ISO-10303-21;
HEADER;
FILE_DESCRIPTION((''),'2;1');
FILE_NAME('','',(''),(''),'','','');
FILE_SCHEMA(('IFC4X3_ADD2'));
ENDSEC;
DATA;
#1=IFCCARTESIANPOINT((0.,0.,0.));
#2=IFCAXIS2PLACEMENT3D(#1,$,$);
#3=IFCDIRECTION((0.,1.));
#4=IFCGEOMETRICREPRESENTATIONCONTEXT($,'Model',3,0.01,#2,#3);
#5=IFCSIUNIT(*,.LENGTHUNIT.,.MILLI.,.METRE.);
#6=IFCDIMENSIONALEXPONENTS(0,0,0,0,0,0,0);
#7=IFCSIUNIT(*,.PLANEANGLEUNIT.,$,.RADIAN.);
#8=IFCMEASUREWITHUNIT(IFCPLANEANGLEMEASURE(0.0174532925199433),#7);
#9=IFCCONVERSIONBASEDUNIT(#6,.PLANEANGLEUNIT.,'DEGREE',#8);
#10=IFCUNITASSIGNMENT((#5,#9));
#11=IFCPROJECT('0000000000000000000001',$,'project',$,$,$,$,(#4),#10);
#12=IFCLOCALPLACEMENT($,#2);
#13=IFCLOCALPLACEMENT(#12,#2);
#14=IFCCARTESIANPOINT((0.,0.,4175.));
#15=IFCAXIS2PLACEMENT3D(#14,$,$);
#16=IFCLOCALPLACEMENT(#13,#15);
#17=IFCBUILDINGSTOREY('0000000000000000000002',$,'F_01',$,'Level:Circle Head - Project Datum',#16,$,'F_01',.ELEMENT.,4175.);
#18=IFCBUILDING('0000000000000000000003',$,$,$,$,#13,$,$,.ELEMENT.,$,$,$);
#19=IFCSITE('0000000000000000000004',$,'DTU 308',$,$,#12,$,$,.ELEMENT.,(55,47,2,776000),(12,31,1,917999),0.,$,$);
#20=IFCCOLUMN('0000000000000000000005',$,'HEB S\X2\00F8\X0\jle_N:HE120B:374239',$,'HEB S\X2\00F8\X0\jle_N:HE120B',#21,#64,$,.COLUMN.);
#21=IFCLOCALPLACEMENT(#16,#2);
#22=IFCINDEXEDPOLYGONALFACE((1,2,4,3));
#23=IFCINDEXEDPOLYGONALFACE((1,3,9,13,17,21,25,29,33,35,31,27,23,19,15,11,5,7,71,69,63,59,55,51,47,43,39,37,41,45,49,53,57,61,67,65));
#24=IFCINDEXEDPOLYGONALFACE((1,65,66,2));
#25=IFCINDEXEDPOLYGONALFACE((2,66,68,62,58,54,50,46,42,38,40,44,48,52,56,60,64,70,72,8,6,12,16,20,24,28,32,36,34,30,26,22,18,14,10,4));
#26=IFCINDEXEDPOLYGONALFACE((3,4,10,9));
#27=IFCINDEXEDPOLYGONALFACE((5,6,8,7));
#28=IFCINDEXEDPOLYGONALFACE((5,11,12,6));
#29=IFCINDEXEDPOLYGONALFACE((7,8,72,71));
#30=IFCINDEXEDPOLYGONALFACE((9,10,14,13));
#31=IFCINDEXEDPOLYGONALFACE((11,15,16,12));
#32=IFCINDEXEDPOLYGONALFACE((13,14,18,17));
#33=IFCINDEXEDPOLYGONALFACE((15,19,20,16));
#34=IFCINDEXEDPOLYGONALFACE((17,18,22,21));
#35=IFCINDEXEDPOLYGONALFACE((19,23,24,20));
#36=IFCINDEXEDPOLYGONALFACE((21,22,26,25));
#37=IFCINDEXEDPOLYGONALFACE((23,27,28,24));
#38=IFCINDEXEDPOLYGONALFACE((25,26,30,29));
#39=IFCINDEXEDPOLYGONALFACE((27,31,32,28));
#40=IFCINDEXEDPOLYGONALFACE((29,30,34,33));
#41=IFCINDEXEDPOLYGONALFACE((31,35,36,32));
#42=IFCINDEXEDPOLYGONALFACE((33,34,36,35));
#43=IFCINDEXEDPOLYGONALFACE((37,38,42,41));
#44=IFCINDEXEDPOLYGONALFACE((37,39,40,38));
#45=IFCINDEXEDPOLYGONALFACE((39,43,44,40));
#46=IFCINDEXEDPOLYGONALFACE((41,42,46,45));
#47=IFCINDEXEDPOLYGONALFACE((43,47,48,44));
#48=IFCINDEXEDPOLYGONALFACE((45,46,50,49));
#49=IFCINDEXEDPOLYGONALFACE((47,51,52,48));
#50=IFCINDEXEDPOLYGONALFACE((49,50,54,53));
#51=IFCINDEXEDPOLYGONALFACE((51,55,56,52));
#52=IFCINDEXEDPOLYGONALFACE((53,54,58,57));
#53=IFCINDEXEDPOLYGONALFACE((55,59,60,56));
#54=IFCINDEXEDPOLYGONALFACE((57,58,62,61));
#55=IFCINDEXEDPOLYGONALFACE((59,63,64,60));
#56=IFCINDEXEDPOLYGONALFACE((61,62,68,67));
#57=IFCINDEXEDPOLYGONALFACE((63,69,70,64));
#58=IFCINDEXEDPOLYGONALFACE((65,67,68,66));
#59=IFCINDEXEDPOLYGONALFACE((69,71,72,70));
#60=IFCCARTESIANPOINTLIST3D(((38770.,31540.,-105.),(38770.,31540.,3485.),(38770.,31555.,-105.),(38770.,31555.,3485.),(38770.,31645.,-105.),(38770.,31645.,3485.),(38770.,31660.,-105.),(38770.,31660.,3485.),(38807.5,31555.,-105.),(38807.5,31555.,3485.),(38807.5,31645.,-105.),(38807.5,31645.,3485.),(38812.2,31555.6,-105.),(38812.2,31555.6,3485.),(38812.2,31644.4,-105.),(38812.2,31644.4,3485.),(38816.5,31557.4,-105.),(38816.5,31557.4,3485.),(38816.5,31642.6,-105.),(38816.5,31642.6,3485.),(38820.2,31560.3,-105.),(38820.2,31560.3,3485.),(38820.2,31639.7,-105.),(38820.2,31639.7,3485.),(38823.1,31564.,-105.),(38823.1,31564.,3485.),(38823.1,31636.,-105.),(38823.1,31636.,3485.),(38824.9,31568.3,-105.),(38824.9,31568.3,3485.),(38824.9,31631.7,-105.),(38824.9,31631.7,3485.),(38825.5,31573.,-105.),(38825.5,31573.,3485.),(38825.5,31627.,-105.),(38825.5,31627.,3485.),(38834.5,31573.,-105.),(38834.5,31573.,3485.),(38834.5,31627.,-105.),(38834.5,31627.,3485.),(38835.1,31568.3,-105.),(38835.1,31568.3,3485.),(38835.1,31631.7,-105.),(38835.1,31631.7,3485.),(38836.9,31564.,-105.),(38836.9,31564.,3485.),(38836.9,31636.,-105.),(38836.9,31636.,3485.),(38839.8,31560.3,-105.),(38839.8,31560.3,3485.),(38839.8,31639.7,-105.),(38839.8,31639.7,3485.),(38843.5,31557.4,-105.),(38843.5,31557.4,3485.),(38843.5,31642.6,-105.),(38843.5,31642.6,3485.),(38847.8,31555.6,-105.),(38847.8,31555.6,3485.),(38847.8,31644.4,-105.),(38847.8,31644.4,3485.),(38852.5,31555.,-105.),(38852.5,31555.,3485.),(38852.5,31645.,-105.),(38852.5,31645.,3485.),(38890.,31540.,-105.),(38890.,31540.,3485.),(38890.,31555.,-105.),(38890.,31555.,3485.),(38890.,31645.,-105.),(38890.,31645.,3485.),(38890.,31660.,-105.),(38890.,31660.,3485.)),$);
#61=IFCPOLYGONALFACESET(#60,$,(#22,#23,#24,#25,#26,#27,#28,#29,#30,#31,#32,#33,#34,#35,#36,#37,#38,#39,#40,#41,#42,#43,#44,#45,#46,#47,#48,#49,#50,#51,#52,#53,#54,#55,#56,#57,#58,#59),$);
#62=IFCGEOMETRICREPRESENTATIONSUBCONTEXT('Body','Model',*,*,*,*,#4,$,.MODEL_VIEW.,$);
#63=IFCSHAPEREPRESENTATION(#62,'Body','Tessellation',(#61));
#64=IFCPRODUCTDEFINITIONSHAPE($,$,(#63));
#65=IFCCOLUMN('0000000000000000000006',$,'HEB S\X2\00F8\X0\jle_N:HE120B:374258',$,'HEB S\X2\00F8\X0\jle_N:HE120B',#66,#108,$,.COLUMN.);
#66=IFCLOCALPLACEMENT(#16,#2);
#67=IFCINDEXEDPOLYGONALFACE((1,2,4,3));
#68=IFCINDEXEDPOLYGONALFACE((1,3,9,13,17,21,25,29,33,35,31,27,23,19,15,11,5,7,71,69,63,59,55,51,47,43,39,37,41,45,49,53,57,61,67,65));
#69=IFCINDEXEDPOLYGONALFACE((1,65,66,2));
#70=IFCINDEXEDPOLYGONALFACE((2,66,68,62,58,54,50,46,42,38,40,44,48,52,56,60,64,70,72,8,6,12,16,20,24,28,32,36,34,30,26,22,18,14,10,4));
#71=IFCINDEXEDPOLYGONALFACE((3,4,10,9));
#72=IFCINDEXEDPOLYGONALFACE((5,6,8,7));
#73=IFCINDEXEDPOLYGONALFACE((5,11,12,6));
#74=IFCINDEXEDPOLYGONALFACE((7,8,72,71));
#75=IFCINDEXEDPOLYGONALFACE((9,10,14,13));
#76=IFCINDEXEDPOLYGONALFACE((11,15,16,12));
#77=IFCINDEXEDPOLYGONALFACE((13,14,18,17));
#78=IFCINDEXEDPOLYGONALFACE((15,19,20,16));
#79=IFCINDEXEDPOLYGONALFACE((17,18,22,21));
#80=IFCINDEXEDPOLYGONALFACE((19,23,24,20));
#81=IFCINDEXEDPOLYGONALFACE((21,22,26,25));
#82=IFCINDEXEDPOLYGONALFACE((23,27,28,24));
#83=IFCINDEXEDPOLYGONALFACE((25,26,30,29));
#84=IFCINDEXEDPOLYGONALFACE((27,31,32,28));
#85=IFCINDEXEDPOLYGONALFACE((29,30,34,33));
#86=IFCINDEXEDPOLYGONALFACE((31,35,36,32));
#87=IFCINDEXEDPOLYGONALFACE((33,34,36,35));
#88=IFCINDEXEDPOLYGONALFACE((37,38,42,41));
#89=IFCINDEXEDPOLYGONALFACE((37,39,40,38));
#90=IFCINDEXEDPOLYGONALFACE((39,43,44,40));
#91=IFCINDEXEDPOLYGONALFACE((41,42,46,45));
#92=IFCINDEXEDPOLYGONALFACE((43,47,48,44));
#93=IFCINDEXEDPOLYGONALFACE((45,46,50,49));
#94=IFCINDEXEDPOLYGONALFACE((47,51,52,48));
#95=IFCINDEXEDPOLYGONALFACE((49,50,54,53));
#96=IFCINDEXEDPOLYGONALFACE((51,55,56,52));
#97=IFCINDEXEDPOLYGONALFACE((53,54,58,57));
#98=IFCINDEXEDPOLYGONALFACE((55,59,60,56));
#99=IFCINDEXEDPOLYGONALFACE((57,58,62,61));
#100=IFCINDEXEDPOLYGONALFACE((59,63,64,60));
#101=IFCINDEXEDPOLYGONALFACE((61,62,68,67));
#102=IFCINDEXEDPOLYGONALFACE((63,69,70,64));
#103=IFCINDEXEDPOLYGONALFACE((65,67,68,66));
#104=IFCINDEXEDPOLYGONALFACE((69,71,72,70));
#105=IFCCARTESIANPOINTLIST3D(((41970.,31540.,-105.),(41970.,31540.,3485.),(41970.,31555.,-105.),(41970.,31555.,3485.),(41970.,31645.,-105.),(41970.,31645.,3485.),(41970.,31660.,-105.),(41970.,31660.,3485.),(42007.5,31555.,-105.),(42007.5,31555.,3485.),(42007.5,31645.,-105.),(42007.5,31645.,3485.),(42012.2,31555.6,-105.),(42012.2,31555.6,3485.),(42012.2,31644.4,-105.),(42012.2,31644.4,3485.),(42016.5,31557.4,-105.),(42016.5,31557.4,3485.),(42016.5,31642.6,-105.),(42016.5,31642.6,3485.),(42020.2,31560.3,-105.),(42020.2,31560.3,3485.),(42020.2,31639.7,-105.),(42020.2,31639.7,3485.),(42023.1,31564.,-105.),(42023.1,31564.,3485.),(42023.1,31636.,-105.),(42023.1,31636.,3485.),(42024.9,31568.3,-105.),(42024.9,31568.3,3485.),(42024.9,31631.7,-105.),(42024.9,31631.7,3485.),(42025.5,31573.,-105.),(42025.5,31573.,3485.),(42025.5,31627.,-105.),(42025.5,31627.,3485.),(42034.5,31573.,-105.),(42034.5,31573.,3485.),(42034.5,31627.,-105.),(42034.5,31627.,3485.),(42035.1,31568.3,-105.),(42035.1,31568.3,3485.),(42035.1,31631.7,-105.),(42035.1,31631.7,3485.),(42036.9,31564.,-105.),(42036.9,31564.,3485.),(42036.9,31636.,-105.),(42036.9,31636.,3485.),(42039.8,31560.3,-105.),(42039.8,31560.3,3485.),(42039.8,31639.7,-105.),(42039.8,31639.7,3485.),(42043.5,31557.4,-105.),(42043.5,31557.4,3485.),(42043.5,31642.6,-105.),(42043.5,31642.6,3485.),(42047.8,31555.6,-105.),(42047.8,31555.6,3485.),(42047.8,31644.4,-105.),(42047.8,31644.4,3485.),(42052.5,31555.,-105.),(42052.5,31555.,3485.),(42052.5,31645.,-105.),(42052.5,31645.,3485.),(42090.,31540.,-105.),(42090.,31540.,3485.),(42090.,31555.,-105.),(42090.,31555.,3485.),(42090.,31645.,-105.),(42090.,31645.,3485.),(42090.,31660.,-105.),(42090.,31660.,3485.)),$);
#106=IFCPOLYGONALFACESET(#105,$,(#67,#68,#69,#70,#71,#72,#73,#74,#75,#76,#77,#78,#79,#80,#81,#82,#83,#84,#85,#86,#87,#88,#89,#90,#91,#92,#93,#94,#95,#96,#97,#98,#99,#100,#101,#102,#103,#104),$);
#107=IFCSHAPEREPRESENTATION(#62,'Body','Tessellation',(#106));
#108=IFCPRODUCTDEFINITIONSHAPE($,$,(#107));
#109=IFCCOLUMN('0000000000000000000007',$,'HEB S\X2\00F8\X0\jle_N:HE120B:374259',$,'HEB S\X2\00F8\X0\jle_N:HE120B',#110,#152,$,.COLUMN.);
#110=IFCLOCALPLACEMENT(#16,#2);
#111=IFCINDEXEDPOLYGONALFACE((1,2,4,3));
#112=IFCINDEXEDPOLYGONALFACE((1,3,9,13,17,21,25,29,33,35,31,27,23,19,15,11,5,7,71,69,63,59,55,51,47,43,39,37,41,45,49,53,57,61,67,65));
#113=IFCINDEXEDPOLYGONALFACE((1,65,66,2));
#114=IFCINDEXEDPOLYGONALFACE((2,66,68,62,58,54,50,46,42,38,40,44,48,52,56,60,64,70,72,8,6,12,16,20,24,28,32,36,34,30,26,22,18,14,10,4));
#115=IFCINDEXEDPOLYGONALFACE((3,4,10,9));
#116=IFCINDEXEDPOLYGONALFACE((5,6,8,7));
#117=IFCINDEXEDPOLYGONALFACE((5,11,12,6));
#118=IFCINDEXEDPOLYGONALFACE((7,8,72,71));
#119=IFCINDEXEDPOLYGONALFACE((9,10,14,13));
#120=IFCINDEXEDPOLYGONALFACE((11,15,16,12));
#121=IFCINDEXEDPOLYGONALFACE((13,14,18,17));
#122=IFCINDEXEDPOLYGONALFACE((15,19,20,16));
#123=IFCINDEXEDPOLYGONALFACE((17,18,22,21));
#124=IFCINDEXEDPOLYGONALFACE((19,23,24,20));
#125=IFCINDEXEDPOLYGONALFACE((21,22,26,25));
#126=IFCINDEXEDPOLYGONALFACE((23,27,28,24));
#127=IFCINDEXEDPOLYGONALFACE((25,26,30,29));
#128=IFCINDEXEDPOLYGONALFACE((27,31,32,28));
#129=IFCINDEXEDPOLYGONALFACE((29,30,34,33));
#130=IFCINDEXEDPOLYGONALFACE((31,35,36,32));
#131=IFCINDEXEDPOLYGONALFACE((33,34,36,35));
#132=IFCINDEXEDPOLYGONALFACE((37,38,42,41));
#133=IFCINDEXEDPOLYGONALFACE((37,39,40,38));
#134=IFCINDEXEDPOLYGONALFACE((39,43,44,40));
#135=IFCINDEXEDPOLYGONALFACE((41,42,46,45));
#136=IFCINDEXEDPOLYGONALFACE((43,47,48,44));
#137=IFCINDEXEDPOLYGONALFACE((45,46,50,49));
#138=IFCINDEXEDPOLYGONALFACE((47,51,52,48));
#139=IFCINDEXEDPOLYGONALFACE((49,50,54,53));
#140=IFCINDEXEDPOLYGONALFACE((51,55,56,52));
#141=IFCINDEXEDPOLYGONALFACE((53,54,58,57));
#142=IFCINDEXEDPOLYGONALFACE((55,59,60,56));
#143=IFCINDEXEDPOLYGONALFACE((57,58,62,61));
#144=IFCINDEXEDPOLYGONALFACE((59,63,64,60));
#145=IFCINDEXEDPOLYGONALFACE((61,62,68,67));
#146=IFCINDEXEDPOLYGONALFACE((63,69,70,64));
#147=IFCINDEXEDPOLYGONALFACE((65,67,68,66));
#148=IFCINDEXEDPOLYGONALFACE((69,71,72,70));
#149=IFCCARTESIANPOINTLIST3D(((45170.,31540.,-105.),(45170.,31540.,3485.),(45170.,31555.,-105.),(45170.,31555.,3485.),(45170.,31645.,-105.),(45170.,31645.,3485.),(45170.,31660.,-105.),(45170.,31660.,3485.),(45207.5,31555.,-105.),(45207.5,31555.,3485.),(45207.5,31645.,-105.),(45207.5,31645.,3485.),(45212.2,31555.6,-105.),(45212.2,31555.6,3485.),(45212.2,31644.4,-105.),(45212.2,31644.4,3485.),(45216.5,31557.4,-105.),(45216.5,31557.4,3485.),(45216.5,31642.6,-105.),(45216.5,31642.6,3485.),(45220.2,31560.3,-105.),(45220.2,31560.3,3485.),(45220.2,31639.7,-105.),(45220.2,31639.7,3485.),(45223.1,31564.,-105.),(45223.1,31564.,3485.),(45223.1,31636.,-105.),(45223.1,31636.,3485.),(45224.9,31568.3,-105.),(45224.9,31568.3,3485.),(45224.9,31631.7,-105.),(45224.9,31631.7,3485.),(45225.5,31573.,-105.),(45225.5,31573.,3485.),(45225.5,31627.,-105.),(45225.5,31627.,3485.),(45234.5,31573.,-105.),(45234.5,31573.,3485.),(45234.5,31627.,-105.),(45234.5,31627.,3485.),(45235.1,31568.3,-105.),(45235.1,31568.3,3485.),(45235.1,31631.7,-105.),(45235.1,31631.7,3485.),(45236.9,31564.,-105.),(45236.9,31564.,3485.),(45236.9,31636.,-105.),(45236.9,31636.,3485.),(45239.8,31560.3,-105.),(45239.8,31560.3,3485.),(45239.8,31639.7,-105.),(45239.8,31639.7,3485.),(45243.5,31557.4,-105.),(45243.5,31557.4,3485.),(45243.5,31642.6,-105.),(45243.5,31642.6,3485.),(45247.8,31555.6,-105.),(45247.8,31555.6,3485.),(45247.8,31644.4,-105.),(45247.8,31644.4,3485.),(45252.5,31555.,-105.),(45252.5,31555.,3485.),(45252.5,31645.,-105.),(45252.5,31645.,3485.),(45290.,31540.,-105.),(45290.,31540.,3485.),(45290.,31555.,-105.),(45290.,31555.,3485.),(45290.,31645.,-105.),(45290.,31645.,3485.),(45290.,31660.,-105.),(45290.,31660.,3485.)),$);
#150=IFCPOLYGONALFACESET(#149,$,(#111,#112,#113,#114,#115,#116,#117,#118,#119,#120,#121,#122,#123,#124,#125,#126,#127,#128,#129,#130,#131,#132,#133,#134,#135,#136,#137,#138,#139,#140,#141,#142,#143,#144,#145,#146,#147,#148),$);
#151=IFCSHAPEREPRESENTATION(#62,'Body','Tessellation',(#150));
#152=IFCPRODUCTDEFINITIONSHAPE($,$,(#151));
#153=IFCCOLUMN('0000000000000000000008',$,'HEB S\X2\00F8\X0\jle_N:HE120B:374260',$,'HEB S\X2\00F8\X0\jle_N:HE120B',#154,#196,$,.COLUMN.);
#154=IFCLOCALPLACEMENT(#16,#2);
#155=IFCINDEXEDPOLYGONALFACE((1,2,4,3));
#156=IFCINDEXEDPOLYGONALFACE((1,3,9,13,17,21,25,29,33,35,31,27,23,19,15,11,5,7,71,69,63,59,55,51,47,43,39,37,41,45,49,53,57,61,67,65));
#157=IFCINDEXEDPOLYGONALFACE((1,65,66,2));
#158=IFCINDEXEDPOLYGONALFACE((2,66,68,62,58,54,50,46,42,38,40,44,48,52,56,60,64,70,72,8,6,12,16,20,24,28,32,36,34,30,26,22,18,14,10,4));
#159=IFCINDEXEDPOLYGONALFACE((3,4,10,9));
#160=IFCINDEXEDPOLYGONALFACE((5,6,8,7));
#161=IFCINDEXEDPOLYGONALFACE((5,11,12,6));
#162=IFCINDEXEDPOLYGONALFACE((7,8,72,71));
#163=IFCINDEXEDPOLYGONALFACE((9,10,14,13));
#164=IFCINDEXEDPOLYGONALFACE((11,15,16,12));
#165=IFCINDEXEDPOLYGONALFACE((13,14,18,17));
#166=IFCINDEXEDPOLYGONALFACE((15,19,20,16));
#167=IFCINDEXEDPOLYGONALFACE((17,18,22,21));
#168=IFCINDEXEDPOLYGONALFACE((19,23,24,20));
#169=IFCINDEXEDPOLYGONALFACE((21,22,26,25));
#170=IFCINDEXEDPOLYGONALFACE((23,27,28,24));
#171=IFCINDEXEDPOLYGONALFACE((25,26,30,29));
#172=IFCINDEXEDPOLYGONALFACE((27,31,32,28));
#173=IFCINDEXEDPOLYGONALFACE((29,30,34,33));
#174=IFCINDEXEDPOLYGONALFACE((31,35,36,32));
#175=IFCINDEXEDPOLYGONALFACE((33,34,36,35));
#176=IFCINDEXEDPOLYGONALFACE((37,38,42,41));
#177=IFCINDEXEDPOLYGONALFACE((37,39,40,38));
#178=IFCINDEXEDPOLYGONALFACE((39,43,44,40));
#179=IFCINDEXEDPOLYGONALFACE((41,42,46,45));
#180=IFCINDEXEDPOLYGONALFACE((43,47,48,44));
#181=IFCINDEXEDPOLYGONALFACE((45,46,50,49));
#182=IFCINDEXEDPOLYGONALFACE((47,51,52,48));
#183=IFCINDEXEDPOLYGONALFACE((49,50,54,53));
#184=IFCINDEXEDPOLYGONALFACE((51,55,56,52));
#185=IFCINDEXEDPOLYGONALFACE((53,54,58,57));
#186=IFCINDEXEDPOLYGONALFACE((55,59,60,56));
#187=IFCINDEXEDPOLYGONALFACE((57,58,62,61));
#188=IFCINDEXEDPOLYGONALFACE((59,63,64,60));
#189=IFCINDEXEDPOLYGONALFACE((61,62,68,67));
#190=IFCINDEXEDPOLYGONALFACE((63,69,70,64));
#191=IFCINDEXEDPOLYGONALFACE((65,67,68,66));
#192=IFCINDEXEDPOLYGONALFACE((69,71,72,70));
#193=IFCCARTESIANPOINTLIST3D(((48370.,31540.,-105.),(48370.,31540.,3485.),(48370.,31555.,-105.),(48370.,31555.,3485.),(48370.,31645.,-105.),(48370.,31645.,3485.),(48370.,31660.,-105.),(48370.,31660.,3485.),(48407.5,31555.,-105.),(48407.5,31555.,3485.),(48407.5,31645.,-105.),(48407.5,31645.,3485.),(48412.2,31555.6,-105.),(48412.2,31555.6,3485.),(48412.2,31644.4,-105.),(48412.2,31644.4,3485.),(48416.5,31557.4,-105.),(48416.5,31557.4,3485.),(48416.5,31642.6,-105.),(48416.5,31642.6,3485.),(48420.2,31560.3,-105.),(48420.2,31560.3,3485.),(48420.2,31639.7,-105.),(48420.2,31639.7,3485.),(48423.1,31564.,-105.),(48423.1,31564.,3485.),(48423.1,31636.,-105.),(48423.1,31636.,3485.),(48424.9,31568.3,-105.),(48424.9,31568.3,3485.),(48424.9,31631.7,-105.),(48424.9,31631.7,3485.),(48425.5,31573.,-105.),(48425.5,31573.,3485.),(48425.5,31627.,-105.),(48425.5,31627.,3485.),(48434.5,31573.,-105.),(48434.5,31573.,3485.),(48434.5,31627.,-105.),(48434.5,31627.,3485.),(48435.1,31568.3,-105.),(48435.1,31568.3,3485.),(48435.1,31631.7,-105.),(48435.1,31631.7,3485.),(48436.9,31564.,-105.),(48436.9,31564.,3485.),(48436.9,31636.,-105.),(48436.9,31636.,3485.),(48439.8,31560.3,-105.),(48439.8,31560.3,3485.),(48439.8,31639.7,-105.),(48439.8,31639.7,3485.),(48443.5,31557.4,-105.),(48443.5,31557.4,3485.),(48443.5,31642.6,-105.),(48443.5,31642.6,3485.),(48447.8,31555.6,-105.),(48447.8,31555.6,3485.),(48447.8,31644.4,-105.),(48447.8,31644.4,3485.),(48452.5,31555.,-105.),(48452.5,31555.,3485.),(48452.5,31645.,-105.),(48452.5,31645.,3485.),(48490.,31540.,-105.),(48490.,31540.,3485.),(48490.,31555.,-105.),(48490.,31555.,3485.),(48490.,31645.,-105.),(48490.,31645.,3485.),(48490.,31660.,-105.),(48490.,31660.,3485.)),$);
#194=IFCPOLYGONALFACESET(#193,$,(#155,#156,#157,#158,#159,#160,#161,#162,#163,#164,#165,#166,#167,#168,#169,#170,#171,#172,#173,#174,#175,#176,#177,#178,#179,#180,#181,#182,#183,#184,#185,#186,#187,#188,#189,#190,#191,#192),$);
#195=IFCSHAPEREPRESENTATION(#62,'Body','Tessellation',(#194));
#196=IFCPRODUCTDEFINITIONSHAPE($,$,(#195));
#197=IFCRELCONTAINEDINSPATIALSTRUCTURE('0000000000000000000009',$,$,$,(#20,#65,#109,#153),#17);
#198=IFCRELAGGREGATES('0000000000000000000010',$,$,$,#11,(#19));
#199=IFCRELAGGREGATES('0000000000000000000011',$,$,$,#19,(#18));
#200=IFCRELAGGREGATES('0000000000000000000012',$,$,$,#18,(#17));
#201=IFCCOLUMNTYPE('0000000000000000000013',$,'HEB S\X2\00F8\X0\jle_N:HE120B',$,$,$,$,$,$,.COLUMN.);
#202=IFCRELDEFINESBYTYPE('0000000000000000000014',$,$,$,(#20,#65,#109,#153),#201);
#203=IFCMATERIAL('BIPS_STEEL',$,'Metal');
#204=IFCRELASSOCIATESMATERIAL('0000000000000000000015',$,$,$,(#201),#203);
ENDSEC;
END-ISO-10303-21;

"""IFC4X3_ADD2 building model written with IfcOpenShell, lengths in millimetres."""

from ifc_helpers import new_model, entity, si_unit, converted_unit, direction, frame, frame_2d, origin, place, context, subcontext, project, spatial, i_section, extrude, source, transform, mapped, material, material_profile, profile_set, type_object, type_shapes, element, save


model = new_model("IFC4X3_ADD2")

# Units and contexts
model_context = context("Model", 3, precision=0.01, world=origin(), true_north=direction((0.0, 1.0)))
body_context = subcontext(model_context, "Body", "Model", "MODEL_VIEW")
ifc_project = project(units=[si_unit("LENGTHUNIT", "METRE", prefix="MILLI"), converted_unit("PLANEANGLEUNIT", "DEGREE", entity("IfcPlaneAngleMeasure", 0.0174532925199433), si_unit("PLANEANGLEUNIT", "RADIAN"), dimensions=[0, 0, 0, 0, 0, 0, 0])], contexts=[model_context])

# Site, building, storey
site_placement = place(None, origin())
site = spatial("IfcSite", under=ifc_project, at=site_placement, Name="DTU 308", CompositionType="ELEMENT", RefLatitude=(55, 47, 2, 776000), RefLongitude=(12, 31, 1, 917999), RefElevation=0.0)
building_placement = place(site_placement, origin())
building = spatial("IfcBuilding", under=site, at=building_placement, CompositionType="ELEMENT")
storey_placement = place(building_placement, frame((0.0, 0.0, 4175.0)))
storey = spatial("IfcBuildingStorey", under=building, at=storey_placement, Name="F_01", ObjectType="Level:Circle Head - Project Datum", LongName="F_01", CompositionType="ELEMENT", Elevation=4175.0)

# Columns
ifc_material_1 = material(Name="BIPS_STEEL", Category="Metal")
ifc_material_profile_1 = material_profile(ifc_material_1, i_section(OverallWidth=120.0, OverallDepth=120.0, WebThickness=9.0, FlangeThickness=15.0, FilletRadius=18.0, at=frame_2d((0.0, 0.0), x_axis=(1.0, 0.0))), Name="HE120B")
ifc_profile_set_1 = profile_set([ifc_material_profile_1], Name="HE120B")
column_type_1 = type_object("IfcColumnType", Name="HEB Søjle_N:HE120B", PredefinedType="COLUMN", material=ifc_profile_set_1)
shared_shape_1 = source(origin(), body_context, "Body", "SweptSolid", [
    extrude(i_section(OverallWidth=120.0, OverallDepth=120.0, WebThickness=9.0, FlangeThickness=15.0, FilletRadius=18.0, at=frame_2d((0.0, 0.0), x_axis=(1.0, 0.0))), frame((0.0, 0.0, 4070.0), z_axis=(0.0, 0.0, 1.0), x_axis=(-1.0, 0.0, 0.0)), (0.0, 0.0, 1.0), 3590.0),
])
type_shapes(column_type_1, [shared_shape_1])
for number, where, name in (
    (1, (38830.0, 31600.0, -4175.0), "HEB Søjle_N:HE120B:374239"),
    (2, (42030.0, 31600.0, -4175.0), "HEB Søjle_N:HE120B:374258"),
    (3, (45230.0, 31600.0, -4175.0), "HEB Søjle_N:HE120B:374259"),
    (4, (48430.0, 31600.0, -4175.0), "HEB Søjle_N:HE120B:374260"),
):
    element("IfcColumn", number, at=place(storey_placement, frame(where)), inside=storey, type_object=column_type_1, Name=name, ObjectType="HEB Søjle_N:HE120B", PredefinedType="COLUMN", context=body_context, shape_type="MappedRepresentation", body=[
        mapped(shared_shape_1, transform((0.0, 0.0, 0.0), scale=1.0)),
    ])

save(model, "model.ifc")
